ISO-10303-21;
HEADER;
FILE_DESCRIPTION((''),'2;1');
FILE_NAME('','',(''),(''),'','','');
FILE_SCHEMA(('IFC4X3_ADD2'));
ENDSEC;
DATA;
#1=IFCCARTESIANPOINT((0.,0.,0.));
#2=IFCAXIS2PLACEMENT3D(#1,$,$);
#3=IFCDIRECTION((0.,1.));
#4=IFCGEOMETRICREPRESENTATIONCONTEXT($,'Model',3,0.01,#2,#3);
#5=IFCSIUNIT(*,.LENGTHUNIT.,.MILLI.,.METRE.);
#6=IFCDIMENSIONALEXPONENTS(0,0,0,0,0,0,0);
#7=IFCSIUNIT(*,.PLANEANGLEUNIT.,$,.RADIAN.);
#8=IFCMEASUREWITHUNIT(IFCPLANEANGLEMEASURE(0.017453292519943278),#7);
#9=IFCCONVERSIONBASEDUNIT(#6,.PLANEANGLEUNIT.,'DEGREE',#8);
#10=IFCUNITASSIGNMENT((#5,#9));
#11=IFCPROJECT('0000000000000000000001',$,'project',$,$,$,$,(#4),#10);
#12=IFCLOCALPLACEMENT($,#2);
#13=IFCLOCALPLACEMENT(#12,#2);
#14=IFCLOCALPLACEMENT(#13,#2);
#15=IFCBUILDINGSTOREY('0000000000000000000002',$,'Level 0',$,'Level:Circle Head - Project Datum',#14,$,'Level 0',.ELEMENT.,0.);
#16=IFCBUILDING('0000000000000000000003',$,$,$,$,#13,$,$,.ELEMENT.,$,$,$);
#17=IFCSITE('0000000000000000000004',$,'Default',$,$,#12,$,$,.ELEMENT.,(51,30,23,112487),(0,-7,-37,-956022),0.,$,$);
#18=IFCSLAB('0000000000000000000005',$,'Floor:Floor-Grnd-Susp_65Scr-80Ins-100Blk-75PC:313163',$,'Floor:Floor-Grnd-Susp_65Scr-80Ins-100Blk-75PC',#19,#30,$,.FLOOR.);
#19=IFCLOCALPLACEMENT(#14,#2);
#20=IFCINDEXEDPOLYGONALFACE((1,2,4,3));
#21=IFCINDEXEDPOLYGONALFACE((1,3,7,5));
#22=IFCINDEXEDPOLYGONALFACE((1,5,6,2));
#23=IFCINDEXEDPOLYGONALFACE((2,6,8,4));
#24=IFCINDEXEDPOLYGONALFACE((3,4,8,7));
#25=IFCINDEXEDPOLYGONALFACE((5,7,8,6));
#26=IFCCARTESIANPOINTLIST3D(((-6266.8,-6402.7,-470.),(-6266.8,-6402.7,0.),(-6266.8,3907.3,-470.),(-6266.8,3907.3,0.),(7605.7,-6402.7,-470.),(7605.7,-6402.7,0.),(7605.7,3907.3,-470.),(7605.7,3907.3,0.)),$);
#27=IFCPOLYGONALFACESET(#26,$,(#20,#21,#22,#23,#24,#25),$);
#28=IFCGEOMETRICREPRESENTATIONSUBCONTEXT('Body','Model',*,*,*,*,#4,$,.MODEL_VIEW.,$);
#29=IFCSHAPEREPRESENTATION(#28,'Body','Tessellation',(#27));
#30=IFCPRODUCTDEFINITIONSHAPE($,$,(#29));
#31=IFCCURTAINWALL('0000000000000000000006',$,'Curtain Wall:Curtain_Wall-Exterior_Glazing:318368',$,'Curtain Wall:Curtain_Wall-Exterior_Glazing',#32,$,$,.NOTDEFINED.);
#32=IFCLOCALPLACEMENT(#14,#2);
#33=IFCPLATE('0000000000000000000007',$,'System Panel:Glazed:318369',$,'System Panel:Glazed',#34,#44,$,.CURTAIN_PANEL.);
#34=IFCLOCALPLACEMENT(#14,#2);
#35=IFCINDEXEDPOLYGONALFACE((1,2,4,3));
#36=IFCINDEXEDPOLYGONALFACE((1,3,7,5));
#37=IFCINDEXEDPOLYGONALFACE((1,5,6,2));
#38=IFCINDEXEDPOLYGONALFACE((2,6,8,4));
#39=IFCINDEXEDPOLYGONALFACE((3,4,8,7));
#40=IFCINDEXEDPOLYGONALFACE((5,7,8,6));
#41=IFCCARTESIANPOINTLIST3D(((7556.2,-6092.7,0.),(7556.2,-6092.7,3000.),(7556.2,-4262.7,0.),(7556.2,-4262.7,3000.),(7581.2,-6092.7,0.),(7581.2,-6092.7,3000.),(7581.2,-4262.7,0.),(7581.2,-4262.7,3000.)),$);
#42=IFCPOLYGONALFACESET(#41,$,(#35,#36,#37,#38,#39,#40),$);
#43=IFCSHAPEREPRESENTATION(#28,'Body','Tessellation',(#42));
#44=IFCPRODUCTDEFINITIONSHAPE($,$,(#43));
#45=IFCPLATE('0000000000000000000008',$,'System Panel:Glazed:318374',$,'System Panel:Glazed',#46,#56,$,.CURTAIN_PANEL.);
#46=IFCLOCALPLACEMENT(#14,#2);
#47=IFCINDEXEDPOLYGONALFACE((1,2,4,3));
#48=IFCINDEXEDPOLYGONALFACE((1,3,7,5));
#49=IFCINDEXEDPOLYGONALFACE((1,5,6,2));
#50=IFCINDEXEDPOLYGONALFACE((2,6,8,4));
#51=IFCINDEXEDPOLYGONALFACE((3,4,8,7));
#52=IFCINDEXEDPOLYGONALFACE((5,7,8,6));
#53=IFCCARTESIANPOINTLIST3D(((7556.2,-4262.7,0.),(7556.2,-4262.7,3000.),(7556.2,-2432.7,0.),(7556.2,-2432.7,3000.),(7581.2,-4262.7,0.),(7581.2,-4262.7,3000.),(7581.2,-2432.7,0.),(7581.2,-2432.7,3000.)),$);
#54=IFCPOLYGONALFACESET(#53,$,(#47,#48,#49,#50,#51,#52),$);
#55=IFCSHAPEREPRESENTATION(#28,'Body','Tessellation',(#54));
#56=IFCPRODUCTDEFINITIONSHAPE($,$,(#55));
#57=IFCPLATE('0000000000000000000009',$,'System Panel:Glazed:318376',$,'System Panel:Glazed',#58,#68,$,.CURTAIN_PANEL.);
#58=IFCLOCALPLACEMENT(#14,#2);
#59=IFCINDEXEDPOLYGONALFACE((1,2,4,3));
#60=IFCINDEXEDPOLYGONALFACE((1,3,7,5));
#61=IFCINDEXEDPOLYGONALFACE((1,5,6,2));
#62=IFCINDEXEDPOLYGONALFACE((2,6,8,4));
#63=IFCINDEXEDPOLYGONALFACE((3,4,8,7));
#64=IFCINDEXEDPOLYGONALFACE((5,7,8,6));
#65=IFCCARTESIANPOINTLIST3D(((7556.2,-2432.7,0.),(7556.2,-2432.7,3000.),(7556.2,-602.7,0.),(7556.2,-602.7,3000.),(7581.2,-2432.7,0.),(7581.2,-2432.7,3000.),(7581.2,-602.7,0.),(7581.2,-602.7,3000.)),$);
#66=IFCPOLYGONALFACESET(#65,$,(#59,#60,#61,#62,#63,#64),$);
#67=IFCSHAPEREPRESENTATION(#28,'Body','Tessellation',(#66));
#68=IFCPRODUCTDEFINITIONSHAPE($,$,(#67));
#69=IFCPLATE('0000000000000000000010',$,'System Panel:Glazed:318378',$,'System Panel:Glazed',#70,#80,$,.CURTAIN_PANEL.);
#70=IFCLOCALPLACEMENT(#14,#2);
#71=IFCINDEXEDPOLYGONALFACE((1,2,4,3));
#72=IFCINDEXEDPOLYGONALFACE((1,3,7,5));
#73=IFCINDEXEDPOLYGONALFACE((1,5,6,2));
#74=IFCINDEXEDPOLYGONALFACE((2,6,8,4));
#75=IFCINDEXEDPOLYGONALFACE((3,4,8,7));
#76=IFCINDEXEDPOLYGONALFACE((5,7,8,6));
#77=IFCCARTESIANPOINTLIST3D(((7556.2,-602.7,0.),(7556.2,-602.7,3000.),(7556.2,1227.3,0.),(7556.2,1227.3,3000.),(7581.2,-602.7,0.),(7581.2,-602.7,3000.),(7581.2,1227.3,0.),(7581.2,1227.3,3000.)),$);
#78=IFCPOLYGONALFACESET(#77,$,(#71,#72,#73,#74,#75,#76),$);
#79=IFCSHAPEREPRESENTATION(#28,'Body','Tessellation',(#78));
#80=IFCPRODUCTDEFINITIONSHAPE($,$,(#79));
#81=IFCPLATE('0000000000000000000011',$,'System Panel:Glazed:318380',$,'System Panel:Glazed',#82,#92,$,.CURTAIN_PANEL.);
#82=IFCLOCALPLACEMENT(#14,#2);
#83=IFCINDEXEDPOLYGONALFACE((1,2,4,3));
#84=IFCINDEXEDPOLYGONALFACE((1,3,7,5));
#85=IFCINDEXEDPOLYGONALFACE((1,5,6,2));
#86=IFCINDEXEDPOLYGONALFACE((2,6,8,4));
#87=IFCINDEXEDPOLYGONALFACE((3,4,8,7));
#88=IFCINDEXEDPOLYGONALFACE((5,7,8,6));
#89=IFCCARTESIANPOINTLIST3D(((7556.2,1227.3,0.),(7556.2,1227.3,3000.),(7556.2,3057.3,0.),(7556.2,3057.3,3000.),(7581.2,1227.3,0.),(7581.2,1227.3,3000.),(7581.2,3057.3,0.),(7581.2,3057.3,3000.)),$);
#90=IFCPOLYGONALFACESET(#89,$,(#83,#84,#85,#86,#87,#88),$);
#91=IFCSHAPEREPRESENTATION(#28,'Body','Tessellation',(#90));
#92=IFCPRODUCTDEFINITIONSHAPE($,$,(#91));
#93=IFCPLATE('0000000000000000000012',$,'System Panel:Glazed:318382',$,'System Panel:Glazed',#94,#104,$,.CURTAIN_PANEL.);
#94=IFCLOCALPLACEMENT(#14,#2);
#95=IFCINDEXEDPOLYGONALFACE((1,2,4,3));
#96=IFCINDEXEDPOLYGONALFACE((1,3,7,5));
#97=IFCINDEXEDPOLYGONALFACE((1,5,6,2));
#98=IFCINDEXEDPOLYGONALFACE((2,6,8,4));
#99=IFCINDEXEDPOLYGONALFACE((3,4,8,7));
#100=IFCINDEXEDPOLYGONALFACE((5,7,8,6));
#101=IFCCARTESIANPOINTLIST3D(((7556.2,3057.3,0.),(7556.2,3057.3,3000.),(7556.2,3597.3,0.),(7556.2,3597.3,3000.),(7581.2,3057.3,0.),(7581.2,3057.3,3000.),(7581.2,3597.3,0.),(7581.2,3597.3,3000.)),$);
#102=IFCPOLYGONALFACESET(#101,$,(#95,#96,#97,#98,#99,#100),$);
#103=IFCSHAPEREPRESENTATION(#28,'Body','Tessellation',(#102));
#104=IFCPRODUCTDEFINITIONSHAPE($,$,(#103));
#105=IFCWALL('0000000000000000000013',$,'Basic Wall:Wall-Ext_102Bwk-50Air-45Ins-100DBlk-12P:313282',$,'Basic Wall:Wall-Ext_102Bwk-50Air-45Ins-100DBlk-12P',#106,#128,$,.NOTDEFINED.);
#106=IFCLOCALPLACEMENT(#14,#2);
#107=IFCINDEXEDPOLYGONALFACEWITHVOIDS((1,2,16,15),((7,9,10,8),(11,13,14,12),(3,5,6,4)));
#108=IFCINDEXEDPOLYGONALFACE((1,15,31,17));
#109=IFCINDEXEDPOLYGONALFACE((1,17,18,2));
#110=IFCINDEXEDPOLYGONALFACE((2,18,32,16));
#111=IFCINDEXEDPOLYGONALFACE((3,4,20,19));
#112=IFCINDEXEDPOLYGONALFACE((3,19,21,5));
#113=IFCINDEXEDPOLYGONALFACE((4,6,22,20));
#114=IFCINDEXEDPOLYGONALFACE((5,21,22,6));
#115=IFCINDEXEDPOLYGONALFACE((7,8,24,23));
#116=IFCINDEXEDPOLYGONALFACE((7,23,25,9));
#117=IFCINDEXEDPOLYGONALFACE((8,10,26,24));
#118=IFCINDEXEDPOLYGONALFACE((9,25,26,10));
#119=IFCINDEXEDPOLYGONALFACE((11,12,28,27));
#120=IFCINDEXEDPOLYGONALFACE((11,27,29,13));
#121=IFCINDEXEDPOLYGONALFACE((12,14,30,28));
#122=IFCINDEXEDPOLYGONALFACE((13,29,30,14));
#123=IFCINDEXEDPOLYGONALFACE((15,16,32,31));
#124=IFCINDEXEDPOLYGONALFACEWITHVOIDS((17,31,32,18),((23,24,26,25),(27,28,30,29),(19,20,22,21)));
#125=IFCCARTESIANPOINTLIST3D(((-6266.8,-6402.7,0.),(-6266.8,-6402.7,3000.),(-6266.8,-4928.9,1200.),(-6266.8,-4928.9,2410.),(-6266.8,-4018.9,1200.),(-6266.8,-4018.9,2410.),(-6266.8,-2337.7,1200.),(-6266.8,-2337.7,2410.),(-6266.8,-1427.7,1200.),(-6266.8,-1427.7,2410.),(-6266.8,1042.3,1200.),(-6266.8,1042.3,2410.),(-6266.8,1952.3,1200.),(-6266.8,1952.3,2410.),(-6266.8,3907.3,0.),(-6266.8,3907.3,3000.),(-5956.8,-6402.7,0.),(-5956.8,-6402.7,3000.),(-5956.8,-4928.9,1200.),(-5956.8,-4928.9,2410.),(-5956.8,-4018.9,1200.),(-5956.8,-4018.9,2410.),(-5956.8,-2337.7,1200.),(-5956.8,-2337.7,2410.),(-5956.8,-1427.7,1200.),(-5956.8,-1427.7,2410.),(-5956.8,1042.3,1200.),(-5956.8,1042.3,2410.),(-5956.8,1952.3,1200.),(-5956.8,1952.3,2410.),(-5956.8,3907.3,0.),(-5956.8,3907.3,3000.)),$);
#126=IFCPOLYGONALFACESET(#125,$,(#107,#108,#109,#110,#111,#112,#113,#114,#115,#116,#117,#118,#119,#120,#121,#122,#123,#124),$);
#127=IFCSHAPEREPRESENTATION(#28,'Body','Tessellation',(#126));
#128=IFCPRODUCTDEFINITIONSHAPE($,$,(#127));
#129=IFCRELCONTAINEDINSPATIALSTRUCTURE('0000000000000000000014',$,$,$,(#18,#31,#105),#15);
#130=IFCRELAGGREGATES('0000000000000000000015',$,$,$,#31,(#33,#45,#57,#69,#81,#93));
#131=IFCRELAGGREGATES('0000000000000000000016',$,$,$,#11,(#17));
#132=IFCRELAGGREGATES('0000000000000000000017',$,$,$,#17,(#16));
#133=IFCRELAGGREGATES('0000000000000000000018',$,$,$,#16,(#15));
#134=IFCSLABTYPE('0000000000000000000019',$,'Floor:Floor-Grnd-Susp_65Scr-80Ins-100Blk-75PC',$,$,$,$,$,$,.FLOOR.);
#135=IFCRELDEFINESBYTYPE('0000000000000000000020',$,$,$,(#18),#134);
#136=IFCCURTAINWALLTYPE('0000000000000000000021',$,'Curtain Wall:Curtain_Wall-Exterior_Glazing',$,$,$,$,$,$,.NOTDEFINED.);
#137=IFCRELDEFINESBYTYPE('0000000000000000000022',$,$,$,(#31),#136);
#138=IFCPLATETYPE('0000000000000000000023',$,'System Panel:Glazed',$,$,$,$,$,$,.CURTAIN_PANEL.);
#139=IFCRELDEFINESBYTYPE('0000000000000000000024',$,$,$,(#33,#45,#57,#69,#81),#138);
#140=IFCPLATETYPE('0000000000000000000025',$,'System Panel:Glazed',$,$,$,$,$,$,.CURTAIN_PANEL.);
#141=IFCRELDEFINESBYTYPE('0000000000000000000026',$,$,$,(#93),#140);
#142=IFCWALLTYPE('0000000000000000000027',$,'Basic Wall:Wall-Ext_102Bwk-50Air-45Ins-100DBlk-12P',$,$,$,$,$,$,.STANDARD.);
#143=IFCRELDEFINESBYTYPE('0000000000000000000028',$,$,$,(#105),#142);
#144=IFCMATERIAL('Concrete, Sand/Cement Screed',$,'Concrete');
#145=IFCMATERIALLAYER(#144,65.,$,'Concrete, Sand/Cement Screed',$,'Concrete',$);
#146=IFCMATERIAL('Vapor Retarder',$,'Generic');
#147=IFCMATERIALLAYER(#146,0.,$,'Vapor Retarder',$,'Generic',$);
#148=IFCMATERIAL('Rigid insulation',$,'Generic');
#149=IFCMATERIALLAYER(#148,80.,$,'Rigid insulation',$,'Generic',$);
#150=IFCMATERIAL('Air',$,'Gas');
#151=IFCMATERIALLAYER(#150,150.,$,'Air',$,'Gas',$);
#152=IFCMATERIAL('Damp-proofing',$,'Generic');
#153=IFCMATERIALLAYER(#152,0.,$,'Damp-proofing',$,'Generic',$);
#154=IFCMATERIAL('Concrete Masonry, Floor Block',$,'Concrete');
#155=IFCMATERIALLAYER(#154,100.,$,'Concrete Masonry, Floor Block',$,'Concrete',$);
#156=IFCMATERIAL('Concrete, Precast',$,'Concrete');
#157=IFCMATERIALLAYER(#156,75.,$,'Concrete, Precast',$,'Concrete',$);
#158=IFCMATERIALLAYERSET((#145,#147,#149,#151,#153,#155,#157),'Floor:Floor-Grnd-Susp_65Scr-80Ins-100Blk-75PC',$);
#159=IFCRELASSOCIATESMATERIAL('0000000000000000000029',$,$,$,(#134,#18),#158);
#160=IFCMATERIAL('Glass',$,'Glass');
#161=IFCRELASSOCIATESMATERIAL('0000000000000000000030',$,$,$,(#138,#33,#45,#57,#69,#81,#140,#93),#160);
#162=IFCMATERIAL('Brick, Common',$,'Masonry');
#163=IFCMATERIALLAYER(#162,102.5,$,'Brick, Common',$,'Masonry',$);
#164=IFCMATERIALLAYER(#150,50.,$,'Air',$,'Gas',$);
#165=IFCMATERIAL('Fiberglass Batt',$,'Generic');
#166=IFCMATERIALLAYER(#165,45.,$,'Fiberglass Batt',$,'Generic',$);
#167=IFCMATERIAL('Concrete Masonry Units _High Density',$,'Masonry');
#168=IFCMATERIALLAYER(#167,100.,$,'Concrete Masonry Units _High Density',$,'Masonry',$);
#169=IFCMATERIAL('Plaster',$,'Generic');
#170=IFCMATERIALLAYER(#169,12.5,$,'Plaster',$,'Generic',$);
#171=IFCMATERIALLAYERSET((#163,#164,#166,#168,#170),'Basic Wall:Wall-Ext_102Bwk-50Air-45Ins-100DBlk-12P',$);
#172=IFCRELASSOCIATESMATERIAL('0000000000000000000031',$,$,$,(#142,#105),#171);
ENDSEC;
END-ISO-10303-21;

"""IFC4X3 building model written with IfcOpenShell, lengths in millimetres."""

from ifc_helpers import new_model, entity, si_unit, converted_unit, direction, frame, frame_2d, origin, origin_2d_with_axis, place, context, subcontext, project, spatial, rectangle, extrude, source, transform, mapped, material, layer, layer_set, layer_usage, type_object, type_shapes, element, aggregate, save


model = new_model("IFC4X3")

# Units and contexts
model_context = context("Model", 3, precision=0.01, world=origin(), true_north=direction((0.0, 1.0)))
body_context = subcontext(model_context, "Body", "Model", "MODEL_VIEW")
ifc_project = project(units=[si_unit("LENGTHUNIT", "METRE", prefix="MILLI"), converted_unit("PLANEANGLEUNIT", "DEGREE", entity("IfcPlaneAngleMeasure", 0.017453292519943278), si_unit("PLANEANGLEUNIT", "RADIAN"), dimensions=[0, 0, 0, 0, 0, 0, 0])], contexts=[model_context])

# Site, building, storey
site_placement = place(None, origin())
site = spatial("IfcSite", under=ifc_project, at=site_placement, Name="Default", CompositionType="ELEMENT", RefLatitude=(51, 30, 23, 112487), RefLongitude=(0, -7, -37, -956022), RefElevation=0.0)
building_placement = place(site_placement, origin())
building = spatial("IfcBuilding", under=site, at=building_placement, CompositionType="ELEMENT")
storey_placement = place(building_placement, origin())
storey = spatial("IfcBuildingStorey", under=building, at=storey_placement, Name="Level 0", ObjectType="Level:Circle Head - Project Datum", LongName="Level 0", CompositionType="ELEMENT", Elevation=0.0)

# Slab
ifc_material_1 = material(Name="Concrete, Sand/Cement Screed", Category="Concrete")
ifc_layer_1 = layer(ifc_material_1, 65.0, Name="Concrete, Sand/Cement Screed", Category="Concrete")
ifc_material_2 = material(Name="Vapor Retarder", Category="Generic")
ifc_layer_2 = layer(ifc_material_2, 0.0, Name="Vapor Retarder", Category="Generic")
ifc_material_3 = material(Name="Rigid insulation", Category="Generic")
ifc_layer_3 = layer(ifc_material_3, 80.0, Name="Rigid insulation", Category="Generic")
ifc_material_4 = material(Name="Air", Category="Gas")
ifc_layer_4 = layer(ifc_material_4, 150.0, Name="Air", Category="Gas")
ifc_material_5 = material(Name="Damp-proofing", Category="Generic")
ifc_layer_5 = layer(ifc_material_5, 0.0, Name="Damp-proofing", Category="Generic")
ifc_material_6 = material(Name="Concrete Masonry, Floor Block", Category="Concrete")
ifc_layer_6 = layer(ifc_material_6, 100.0, Name="Concrete Masonry, Floor Block", Category="Concrete")
ifc_material_7 = material(Name="Concrete, Precast", Category="Concrete")
ifc_layer_7 = layer(ifc_material_7, 75.0, Name="Concrete, Precast", Category="Concrete")
ifc_layer_set_1 = layer_set([ifc_layer_1, ifc_layer_2, ifc_layer_3, ifc_layer_4, ifc_layer_5, ifc_layer_6, ifc_layer_7], Name="Floor:Floor-Grnd-Susp_65Scr-80Ins-100Blk-75PC")
ifc_layer_usage = layer_usage(ifc_layer_set_1, "AXIS3", "POSITIVE", 0.0)
slab_type = type_object("IfcSlabType", Name="Floor:Floor-Grnd-Susp_65Scr-80Ins-100Blk-75PC", PredefinedType="FLOOR", material=ifc_layer_set_1)
slab_placement = place(storey_placement, origin())
element("IfcSlab", 1, at=slab_placement, inside=storey, type_object=slab_type, material=ifc_layer_usage, Name="Floor:Floor-Grnd-Susp_65Scr-80Ins-100Blk-75PC:313163", ObjectType="Floor:Floor-Grnd-Susp_65Scr-80Ins-100Blk-75PC", PredefinedType="FLOOR", context=body_context, shape_type="SweptSolid", body=[
    extrude(rectangle(XDim=10310.0, YDim=13872.5, at=frame_2d((0.0, 0.0), x_axis=(1.0, 0.0))), frame((669.4, -1247.7, 0.0), z_axis=(0.0, 0.0, -1.0), x_axis=(0.0, 1.0, 0.0)), (0.0, 0.0, 1.0), 470.0),
])

# Curtain wall, plates
curtain_wall_type = type_object("IfcCurtainWallType", Name="Curtain Wall:Curtain_Wall-Exterior_Glazing", PredefinedType="NOTDEFINED")
curtain_wall_placement = place(storey_placement, origin())
curtain_wall = element("IfcCurtainWall", 2, at=curtain_wall_placement, inside=storey, type_object=curtain_wall_type, Name="Curtain Wall:Curtain_Wall-Exterior_Glazing:318368", ObjectType="Curtain Wall:Curtain_Wall-Exterior_Glazing", PredefinedType="NOTDEFINED")
ifc_material_8 = material(Name="Glass", Category="Glass")
plate_type_1 = type_object("IfcPlateType", Name="System Panel:Glazed", PredefinedType="CURTAIN_PANEL", material=ifc_material_8)
shared_shape_1 = source(origin(), body_context, "Body", "SweptSolid", [
    extrude(rectangle(XDim=25.0, YDim=1830.0, at=origin_2d_with_axis()), frame((915.0, 12.5, 0.0), z_axis=(0.0, 0.0, 1.0), x_axis=(0.0, 1.0, 0.0)), (0.0, 0.0, 1.0), 3000.0),
])
type_shapes(plate_type_1, [shared_shape_1])
plate_1_placement = place(curtain_wall_placement, frame((7581.2, -6092.7, 0.0), z_axis=(0.0, 0.0, 1.0), x_axis=(0.0, 1.0, 0.0)))
plate_1 = element("IfcPlate", 3, at=plate_1_placement, type_object=plate_type_1, material=ifc_material_8, Name="System Panel:Glazed:318369", ObjectType="System Panel:Glazed", PredefinedType="CURTAIN_PANEL", context=body_context, shape_type="MappedRepresentation", body=[
    mapped(shared_shape_1, transform((0.0, 0.0, 0.0), scale=1.0)),
])
plate_2_placement = place(curtain_wall_placement, frame((7581.2, -4262.7, 0.0), z_axis=(0.0, 0.0, 1.0), x_axis=(0.0, 1.0, 0.0)))
plate_2 = element("IfcPlate", 4, at=plate_2_placement, type_object=plate_type_1, material=ifc_material_8, Name="System Panel:Glazed:318374", ObjectType="System Panel:Glazed", PredefinedType="CURTAIN_PANEL", context=body_context, shape_type="MappedRepresentation", body=[
    mapped(shared_shape_1, transform((0.0, 0.0, 0.0), scale=1.0)),
])
plate_3_placement = place(curtain_wall_placement, frame((7581.2, -2432.7, 0.0), z_axis=(0.0, 0.0, 1.0), x_axis=(0.0, 1.0, 0.0)))
plate_3 = element("IfcPlate", 5, at=plate_3_placement, type_object=plate_type_1, material=ifc_material_8, Name="System Panel:Glazed:318376", ObjectType="System Panel:Glazed", PredefinedType="CURTAIN_PANEL", context=body_context, shape_type="MappedRepresentation", body=[
    mapped(shared_shape_1, transform((0.0, 0.0, 0.0), scale=1.0)),
])
plate_4_placement = place(curtain_wall_placement, frame((7581.2, -602.7, 0.0), z_axis=(0.0, 0.0, 1.0), x_axis=(0.0, 1.0, 0.0)))
plate_4 = element("IfcPlate", 6, at=plate_4_placement, type_object=plate_type_1, material=ifc_material_8, Name="System Panel:Glazed:318378", ObjectType="System Panel:Glazed", PredefinedType="CURTAIN_PANEL", context=body_context, shape_type="MappedRepresentation", body=[
    mapped(shared_shape_1, transform((0.0, 0.0, 0.0), scale=1.0)),
])
plate_5_placement = place(curtain_wall_placement, frame((7581.2, 1227.3, 0.0), z_axis=(0.0, 0.0, 1.0), x_axis=(0.0, 1.0, 0.0)))
plate_5 = element("IfcPlate", 7, at=plate_5_placement, type_object=plate_type_1, material=ifc_material_8, Name="System Panel:Glazed:318380", ObjectType="System Panel:Glazed", PredefinedType="CURTAIN_PANEL", context=body_context, shape_type="MappedRepresentation", body=[
    mapped(shared_shape_1, transform((0.0, 0.0, 0.0), scale=1.0)),
])
plate_type_2 = type_object("IfcPlateType", Name="System Panel:Glazed", PredefinedType="CURTAIN_PANEL", material=ifc_material_8)
shared_shape_2 = source(origin(), body_context, "Body", "SweptSolid", [
    extrude(rectangle(XDim=25.0, YDim=540.0, at=origin_2d_with_axis()), frame((270.0, 12.5, 0.0), z_axis=(0.0, 0.0, 1.0), x_axis=(0.0, 1.0, 0.0)), (0.0, 0.0, 1.0), 3000.0),
])
type_shapes(plate_type_2, [shared_shape_2])
plate_6_placement = place(curtain_wall_placement, frame((7581.2, 3057.3, 0.0), z_axis=(0.0, 0.0, 1.0), x_axis=(0.0, 1.0, 0.0)))
plate_6 = element("IfcPlate", 8, at=plate_6_placement, type_object=plate_type_2, material=ifc_material_8, Name="System Panel:Glazed:318382", ObjectType="System Panel:Glazed", PredefinedType="CURTAIN_PANEL", context=body_context, shape_type="MappedRepresentation", body=[
    mapped(shared_shape_2, transform((0.0, 0.0, 0.0), scale=1.0)),
])
aggregate(curtain_wall, [plate_1, plate_2, plate_3, plate_4, plate_5, plate_6])

# Wall, openings
ifc_material_9 = material(Name="Brick, Common", Category="Masonry")
ifc_layer_8 = layer(ifc_material_9, 102.5, Name="Brick, Common", Category="Masonry")
ifc_layer_9 = layer(ifc_material_4, 50.0, Name="Air", Category="Gas")
ifc_material_10 = material(Name="Fiberglass Batt", Category="Generic")
ifc_layer_10 = layer(ifc_material_10, 45.0, Name="Fiberglass Batt", Category="Generic")
ifc_material_11 = material(Name="Concrete Masonry Units _High Density", Category="Masonry")
ifc_layer_11 = layer(ifc_material_11, 100.0, Name="Concrete Masonry Units _High Density", Category="Masonry")
ifc_material_12 = material(Name="Plaster", Category="Generic")
ifc_layer_12 = layer(ifc_material_12, 12.5, Name="Plaster", Category="Generic")
ifc_layer_set_2 = layer_set([ifc_layer_8, ifc_layer_9, ifc_layer_10, ifc_layer_11, ifc_layer_12], Name="Basic Wall:Wall-Ext_102Bwk-50Air-45Ins-100DBlk-12P")
wall_type_1 = type_object("IfcWallType", Name="Basic Wall:Wall-Ext_102Bwk-50Air-45Ins-100DBlk-12P", PredefinedType="STANDARD", material=ifc_layer_set_2)
wall_1_placement = place(storey_placement, frame((-6111.8, 3907.3, 0.0), z_axis=(0.0, 0.0, 1.0), x_axis=(0.0, -1.0, 0.0)))
wall_1 = element("IfcWall", 9, at=wall_1_placement, inside=storey, type_object=wall_type_1, material=ifc_layer_set_2, Name="Basic Wall:Wall-Ext_102Bwk-50Air-45Ins-100DBlk-12P:313282", ObjectType="Basic Wall:Wall-Ext_102Bwk-50Air-45Ins-100DBlk-12P", PredefinedType="NOTDEFINED", context=body_context, shape_type="SweptSolid", body=[
    extrude(rectangle(XDim=10310.0, YDim=310.0, at=frame_2d((5155.0, 0.0), x_axis=(-1.0, 0.0))), origin(), (0.0, 0.0, 1.0), 3000.0),
])
opening_1_placement = place(wall_1_placement, frame((2865.0, 155.0, 1200.0)))
element("IfcOpeningElement", 10, at=opening_1_placement, cuts=wall_1, PredefinedType="OPENING", context=body_context, shape_type="SweptSolid", body=[
    extrude(rectangle(XDim=1210.0, YDim=910.0, at=frame_2d((605.0, 455.0), x_axis=(-1.0, 0.0))), frame((0.0, 0.0, 0.0), z_axis=(0.0, -1.0, 0.0), x_axis=(0.0, 0.0, 1.0)), (0.0, 0.0, 1.0), 310.0),
])
opening_2_placement = place(wall_1_placement, frame((6245.0, 155.0, 1200.0)))
element("IfcOpeningElement", 11, at=opening_2_placement, cuts=wall_1, PredefinedType="OPENING", context=body_context, shape_type="SweptSolid", body=[
    extrude(rectangle(XDim=1210.0, YDim=910.0, at=frame_2d((605.0, 455.0), x_axis=(-1.0, 0.0))), frame((0.0, 0.0, 0.0), z_axis=(0.0, -1.0, 0.0), x_axis=(0.0, 0.0, 1.0)), (0.0, 0.0, 1.0), 310.0),
])
opening_3_placement = place(wall_1_placement, frame((8836.3, 155.0, 1200.0)))
element("IfcOpeningElement", 12, at=opening_3_placement, cuts=wall_1, PredefinedType="OPENING", context=body_context, shape_type="SweptSolid", body=[
    extrude(rectangle(XDim=1210.0, YDim=910.0, at=frame_2d((605.0, 455.0), x_axis=(-1.0, 0.0))), frame((0.0, 0.0, 0.0), z_axis=(0.0, -1.0, 0.0), x_axis=(0.0, 0.0, 1.0)), (0.0, 0.0, 1.0), 310.0),
])

save(model, "model.ifc")
